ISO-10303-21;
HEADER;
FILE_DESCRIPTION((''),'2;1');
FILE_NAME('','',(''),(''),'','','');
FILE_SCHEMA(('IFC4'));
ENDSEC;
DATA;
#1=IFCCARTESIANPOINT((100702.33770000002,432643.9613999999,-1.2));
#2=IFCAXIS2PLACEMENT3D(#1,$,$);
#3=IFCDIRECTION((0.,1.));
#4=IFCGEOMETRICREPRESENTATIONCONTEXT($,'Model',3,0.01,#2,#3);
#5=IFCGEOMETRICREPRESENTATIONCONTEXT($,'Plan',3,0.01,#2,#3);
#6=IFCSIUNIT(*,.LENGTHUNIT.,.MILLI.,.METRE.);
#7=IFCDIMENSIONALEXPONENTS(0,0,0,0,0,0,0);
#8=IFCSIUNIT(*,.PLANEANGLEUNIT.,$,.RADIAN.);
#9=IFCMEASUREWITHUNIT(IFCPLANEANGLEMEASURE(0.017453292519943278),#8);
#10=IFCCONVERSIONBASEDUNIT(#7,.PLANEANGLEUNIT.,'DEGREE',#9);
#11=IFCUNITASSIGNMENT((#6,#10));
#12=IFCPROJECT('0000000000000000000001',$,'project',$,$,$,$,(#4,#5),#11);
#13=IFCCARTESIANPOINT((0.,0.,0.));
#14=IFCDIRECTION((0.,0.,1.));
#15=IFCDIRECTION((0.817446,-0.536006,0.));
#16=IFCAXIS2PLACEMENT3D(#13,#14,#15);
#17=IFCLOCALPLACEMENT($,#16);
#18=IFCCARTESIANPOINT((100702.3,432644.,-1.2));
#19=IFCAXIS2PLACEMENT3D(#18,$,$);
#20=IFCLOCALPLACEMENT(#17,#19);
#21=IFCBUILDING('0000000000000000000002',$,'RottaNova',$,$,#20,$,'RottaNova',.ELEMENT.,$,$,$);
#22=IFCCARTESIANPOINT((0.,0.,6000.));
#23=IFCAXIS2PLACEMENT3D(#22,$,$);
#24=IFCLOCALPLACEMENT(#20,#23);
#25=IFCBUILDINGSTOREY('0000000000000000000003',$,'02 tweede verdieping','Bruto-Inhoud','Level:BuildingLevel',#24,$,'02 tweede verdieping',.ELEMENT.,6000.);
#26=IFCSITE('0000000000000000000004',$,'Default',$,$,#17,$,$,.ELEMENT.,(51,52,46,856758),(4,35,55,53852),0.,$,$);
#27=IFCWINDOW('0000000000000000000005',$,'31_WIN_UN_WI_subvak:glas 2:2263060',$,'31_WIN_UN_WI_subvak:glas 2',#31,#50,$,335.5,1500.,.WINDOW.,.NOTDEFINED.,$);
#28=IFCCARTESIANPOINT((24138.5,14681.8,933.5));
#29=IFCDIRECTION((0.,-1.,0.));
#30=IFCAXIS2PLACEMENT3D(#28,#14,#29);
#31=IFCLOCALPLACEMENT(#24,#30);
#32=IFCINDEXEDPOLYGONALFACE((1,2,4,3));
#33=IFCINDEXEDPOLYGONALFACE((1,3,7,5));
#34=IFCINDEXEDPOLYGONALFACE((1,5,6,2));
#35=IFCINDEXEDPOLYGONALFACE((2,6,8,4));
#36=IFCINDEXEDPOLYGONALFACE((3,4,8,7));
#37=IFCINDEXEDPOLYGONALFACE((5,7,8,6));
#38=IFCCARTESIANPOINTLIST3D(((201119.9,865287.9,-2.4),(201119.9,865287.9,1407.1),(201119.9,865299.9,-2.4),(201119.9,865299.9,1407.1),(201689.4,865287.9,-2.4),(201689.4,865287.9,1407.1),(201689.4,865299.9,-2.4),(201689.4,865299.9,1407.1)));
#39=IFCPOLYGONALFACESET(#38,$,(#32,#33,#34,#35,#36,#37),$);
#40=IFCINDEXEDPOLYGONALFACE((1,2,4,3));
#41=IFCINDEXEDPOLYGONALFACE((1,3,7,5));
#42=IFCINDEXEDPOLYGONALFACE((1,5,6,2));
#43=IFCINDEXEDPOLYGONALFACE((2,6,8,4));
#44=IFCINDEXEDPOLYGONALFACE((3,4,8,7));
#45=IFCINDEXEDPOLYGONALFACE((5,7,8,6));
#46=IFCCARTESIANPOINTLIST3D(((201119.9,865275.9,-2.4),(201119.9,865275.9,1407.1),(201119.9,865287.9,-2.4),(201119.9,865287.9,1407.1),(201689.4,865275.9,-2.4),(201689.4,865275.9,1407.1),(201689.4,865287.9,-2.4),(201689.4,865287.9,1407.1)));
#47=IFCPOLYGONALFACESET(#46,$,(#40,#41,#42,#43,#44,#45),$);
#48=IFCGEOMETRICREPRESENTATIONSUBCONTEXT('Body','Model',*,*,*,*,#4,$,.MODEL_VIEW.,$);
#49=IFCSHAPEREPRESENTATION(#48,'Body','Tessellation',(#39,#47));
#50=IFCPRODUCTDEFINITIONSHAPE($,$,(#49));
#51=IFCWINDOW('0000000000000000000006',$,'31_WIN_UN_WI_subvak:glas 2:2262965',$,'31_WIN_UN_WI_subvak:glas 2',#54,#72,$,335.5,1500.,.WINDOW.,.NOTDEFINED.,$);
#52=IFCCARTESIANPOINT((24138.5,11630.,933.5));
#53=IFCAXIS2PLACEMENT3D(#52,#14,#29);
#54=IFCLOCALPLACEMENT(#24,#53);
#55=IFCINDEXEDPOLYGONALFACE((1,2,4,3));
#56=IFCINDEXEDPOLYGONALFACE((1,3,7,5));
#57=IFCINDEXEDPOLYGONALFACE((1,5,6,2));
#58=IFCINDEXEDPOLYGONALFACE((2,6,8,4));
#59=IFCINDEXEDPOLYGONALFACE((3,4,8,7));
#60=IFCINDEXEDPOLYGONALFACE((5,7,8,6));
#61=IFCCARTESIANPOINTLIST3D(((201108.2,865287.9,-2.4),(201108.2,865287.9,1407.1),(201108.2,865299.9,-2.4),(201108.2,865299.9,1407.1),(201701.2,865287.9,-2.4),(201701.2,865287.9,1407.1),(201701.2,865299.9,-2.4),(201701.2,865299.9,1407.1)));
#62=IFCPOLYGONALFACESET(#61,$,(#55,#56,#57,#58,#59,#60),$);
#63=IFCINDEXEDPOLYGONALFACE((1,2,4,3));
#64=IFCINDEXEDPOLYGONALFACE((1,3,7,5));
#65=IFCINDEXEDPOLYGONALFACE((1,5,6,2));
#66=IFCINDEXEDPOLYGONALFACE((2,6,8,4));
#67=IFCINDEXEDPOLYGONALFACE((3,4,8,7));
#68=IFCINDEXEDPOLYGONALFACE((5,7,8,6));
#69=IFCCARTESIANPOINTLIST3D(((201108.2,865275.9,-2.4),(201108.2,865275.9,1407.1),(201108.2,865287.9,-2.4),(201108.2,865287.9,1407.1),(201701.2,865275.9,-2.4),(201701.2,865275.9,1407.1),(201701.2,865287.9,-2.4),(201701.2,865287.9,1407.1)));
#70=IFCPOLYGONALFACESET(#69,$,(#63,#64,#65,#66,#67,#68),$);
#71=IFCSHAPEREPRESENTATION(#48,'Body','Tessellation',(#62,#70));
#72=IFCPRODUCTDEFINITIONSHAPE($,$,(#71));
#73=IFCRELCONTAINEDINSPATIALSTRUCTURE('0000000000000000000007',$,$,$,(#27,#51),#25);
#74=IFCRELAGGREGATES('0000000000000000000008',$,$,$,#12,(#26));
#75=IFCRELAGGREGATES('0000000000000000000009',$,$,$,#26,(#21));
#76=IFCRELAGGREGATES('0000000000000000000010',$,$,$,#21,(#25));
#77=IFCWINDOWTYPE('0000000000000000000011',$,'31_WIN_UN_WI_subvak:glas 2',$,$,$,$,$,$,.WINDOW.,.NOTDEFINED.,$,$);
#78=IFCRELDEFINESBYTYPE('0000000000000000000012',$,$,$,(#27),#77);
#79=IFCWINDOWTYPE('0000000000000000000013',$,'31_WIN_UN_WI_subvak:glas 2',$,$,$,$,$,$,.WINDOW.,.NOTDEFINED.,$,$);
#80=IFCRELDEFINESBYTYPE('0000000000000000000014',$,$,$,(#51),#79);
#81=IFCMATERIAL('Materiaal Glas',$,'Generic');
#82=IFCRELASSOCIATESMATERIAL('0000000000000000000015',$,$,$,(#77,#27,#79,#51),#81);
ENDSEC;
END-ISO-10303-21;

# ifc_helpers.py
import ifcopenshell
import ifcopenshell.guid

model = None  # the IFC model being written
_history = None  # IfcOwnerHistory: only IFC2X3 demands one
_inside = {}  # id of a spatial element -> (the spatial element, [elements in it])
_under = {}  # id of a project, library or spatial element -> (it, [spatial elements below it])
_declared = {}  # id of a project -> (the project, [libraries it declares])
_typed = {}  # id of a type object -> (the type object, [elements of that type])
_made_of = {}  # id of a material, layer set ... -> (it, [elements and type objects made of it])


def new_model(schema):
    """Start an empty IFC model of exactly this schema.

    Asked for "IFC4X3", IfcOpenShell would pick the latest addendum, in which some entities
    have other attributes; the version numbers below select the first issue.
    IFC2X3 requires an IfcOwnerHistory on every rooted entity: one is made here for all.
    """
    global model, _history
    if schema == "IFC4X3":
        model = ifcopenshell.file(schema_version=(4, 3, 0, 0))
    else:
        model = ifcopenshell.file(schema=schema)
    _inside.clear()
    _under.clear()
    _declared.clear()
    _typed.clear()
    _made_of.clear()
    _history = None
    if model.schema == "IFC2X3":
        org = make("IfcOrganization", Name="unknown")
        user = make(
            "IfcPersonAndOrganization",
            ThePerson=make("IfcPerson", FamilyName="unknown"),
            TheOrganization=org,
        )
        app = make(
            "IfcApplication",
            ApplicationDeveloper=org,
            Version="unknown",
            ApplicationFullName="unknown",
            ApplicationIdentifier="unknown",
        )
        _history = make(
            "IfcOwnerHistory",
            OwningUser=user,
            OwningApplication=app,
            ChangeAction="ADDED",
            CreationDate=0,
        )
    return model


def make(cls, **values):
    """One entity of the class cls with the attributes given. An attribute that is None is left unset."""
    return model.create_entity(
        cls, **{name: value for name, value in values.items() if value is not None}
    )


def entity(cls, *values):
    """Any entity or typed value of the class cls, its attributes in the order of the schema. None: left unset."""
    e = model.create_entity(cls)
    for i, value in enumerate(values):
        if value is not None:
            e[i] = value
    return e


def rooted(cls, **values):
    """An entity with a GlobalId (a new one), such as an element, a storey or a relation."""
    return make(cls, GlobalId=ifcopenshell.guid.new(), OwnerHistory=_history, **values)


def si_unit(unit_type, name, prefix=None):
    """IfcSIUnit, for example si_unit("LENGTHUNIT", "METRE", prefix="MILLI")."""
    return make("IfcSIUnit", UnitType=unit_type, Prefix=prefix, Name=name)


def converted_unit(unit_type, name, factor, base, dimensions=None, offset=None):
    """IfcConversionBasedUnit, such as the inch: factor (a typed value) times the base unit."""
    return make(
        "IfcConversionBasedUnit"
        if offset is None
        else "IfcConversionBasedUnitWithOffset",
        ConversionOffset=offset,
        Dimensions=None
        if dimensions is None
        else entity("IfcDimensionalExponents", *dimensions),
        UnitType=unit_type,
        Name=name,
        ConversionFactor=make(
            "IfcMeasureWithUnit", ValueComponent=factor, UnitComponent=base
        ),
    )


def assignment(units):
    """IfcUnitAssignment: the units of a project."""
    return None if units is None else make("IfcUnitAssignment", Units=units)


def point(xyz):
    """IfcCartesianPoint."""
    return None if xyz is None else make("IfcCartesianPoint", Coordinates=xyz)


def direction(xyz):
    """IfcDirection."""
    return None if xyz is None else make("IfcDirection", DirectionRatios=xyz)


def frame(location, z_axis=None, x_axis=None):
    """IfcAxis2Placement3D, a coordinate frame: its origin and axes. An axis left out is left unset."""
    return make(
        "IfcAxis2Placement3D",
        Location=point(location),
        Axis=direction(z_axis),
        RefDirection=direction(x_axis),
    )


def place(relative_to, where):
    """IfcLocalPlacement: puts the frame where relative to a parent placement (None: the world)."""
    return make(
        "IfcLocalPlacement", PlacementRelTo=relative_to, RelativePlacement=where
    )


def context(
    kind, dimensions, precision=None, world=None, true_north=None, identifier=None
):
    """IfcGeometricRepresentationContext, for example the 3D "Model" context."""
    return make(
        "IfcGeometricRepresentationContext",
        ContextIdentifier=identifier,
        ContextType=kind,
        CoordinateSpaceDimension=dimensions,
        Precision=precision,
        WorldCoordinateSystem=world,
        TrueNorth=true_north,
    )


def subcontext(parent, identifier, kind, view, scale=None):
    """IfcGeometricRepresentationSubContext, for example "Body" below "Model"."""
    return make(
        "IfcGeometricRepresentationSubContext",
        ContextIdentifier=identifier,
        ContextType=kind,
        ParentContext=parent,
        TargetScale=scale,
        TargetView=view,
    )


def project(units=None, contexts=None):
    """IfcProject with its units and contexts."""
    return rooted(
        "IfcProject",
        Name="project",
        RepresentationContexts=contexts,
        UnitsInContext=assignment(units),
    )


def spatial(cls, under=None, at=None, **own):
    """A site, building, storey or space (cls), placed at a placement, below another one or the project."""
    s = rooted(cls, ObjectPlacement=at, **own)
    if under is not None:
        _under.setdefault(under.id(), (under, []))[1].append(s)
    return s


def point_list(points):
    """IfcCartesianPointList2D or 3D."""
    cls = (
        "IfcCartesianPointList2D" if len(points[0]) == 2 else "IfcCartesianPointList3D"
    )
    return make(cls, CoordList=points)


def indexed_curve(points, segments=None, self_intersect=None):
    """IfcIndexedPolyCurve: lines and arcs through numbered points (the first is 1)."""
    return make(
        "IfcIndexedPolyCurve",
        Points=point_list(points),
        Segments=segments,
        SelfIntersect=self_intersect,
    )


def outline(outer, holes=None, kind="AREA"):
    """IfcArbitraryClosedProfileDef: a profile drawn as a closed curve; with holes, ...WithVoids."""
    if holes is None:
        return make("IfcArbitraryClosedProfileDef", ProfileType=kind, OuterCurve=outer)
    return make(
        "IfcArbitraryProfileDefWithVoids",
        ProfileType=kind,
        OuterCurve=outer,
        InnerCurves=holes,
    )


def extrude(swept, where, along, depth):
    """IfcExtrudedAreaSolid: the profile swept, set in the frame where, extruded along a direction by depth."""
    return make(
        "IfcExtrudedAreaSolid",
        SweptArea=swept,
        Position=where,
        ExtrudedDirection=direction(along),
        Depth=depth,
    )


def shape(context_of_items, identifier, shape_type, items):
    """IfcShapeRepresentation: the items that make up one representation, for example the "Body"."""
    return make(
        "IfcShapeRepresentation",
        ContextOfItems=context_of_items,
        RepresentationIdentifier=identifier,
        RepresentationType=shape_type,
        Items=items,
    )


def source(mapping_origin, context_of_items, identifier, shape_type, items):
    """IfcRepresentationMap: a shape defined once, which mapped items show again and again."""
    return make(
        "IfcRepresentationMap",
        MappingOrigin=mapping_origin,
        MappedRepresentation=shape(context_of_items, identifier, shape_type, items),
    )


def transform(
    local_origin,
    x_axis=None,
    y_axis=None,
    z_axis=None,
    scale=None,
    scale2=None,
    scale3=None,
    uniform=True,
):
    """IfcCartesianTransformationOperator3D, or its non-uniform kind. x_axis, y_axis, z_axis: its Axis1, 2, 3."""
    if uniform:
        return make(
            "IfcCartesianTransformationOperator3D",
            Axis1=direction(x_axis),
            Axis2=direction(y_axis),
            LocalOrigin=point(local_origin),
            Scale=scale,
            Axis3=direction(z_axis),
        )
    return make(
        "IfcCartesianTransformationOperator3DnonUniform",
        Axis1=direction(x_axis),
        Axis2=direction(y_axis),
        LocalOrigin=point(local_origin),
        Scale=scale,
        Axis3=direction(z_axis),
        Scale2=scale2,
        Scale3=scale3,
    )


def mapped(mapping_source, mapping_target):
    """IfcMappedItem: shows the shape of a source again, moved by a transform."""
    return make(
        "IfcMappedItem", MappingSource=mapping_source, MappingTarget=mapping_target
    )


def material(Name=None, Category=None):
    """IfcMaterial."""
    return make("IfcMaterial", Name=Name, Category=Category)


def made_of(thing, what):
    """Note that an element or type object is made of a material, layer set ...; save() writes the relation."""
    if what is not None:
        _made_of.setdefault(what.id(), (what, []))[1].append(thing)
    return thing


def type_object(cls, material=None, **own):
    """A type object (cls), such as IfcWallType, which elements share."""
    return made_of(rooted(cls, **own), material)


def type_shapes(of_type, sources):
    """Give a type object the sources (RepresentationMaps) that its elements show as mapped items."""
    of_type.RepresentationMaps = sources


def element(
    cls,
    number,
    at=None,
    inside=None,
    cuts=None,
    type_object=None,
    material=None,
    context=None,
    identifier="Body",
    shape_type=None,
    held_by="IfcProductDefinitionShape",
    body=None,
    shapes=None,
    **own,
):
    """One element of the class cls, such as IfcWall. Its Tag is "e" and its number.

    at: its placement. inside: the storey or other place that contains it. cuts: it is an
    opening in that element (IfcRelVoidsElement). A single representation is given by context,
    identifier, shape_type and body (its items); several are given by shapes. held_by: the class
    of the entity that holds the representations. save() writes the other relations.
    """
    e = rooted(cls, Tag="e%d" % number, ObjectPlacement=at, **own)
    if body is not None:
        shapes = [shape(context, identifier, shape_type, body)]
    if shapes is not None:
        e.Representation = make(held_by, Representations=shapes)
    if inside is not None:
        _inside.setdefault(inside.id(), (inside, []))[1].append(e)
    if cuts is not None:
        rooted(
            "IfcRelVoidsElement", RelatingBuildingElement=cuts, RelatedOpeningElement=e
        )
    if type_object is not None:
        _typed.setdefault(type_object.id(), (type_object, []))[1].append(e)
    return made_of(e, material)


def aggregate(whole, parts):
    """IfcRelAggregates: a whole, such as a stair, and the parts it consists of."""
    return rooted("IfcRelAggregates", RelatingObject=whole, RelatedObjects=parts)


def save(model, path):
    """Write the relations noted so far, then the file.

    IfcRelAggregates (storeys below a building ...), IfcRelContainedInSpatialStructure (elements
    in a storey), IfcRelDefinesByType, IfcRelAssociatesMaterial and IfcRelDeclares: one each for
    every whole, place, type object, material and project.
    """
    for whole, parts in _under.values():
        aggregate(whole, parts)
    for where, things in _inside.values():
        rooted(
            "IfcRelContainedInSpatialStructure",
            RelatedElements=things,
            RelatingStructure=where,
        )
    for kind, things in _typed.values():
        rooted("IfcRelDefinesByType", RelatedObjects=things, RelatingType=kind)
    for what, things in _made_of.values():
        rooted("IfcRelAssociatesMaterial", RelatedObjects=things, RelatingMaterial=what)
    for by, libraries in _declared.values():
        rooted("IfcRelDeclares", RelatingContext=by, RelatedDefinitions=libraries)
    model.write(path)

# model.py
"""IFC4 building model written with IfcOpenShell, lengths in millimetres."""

from ifc_helpers import new_model, entity, si_unit, converted_unit, direction, frame, place, context, subcontext, project, spatial, indexed_curve, outline, extrude, source, transform, mapped, material, type_object, type_shapes, element, save


model = new_model("IFC4")

# Units and contexts
model_context = context("Model", 3, precision=0.01, world=frame((100702.33770000002, 432643.9613999999, -1.2)), true_north=direction((0.0, 1.0)))
plan_context = context("Plan", 3, precision=0.01, world=frame((100702.33770000002, 432643.9613999999, -1.2)), true_north=direction((0.0, 1.0)))
body_context = subcontext(model_context, "Body", "Model", "MODEL_VIEW")
ifc_project = project(units=[si_unit("LENGTHUNIT", "METRE", prefix="MILLI"), converted_unit("PLANEANGLEUNIT", "DEGREE", entity("IfcPlaneAngleMeasure", 0.017453292519943278), si_unit("PLANEANGLEUNIT", "RADIAN"), dimensions=[0, 0, 0, 0, 0, 0, 0])], contexts=[model_context, plan_context])

# Site, building, storey
site_placement = place(None, frame((0.0, 0.0, 0.0), z_axis=(0.0, 0.0, 1.0), x_axis=(0.817446, -0.536006, 0.0)))
site = spatial("IfcSite", under=ifc_project, at=site_placement, Name="Default", CompositionType="ELEMENT", RefLatitude=(51, 52, 46, 856758), RefLongitude=(4, 35, 55, 53852), RefElevation=0.0)
building_placement = place(site_placement, frame((100702.3, 432644.0, -1.2)))
building = spatial("IfcBuilding", under=site, at=building_placement, Name="RottaNova", LongName="RottaNova", CompositionType="ELEMENT")
storey_placement = place(building_placement, frame((0.0, 0.0, 6000.0)))
storey = spatial("IfcBuildingStorey", under=building, at=storey_placement, Name="02 tweede verdieping", Description="Bruto-Inhoud", ObjectType="Level:BuildingLevel", LongName="02 tweede verdieping", CompositionType="ELEMENT", Elevation=6000.0)

# Shared definitions
ifc_material_1 = material(Name="Materiaal Glas", Category="Generic")

# Windows
window_type_1 = type_object("IfcWindowType", Name="31_WIN_UN_WI_subvak:glas 2", PartitioningType="NOTDEFINED", PredefinedType="WINDOW", material=ifc_material_1)
shared_shape_1 = source(frame((100702.3, 432644.0, -1.2)), body_context, "Body", "SweptSolid", [
    extrude(outline(indexed_curve([(-6.0, -284.7), (6.0, -284.7), (6.0, 284.7), (-6.0, 284.7), (-6.0, -284.7)], self_intersect=False)), frame((0.0, 6.0, 0.0), z_axis=(0.0, 0.0, 1.0), x_axis=(0.0, -1.0, 0.0)), (0.0, 0.0, 1.0), 1409.5),
    extrude(outline(indexed_curve([(-6.0, -284.8), (6.0, -284.8), (6.0, 284.8), (-6.0, 284.8), (-6.0, -284.8)], self_intersect=False)), frame((0.0, -6.0, 0.0), z_axis=(0.0, 0.0, 1.0), x_axis=(0.0, -1.0, 0.0)), (0.0, 0.0, 1.0), 1409.5),
])
type_shapes(window_type_1, [shared_shape_1])
for number, where, z_axis, x_axis, name in (
    (1, (24138.5, 14681.8, 933.5), (0.0, 0.0, 1.0), (0.0, -1.0, 0.0), "31_WIN_UN_WI_subvak:glas 2:2263060"),
):
    element("IfcWindow", number, at=place(storey_placement, frame(where, z_axis=z_axis, x_axis=x_axis)), inside=storey, type_object=window_type_1, material=ifc_material_1, Name=name, ObjectType="31_WIN_UN_WI_subvak:glas 2", OverallHeight=335.5, OverallWidth=1500.0, PartitioningType="NOTDEFINED", PredefinedType="WINDOW", context=body_context, shape_type="MappedRepresentation", body=[
        mapped(shared_shape_1, transform((100702.3, 432644.0, -1.2), scale=1.0)),
    ])
window_type_2 = type_object("IfcWindowType", Name="31_WIN_UN_WI_subvak:glas 2", PartitioningType="NOTDEFINED", PredefinedType="WINDOW", material=ifc_material_1)
shared_shape_2 = source(frame((100702.3, 432644.0, -1.2)), body_context, "Body", "SweptSolid", [
    extrude(outline(indexed_curve([(-6.0, -296.5), (6.0, -296.5), (6.0, 296.5), (-6.0, 296.5), (-6.0, -296.5)], self_intersect=False)), frame((0.0, 6.0, 0.0), z_axis=(0.0, 0.0, 1.0), x_axis=(0.0, -1.0, 0.0)), (0.0, 0.0, 1.0), 1409.5),
    extrude(outline(indexed_curve([(-6.0, -296.5), (6.0, -296.5), (6.0, 296.5), (-6.0, 296.5), (-6.0, -296.5)], self_intersect=False)), frame((0.0, -6.0, 0.0), z_axis=(0.0, 0.0, 1.0), x_axis=(0.0, -1.0, 0.0)), (0.0, 0.0, 1.0), 1409.5),
])
type_shapes(window_type_2, [shared_shape_2])
window_1_placement = place(storey_placement, frame((24138.5, 11630.0, 933.5), z_axis=(0.0, 0.0, 1.0), x_axis=(0.0, -1.0, 0.0)))
element("IfcWindow", 2, at=window_1_placement, inside=storey, type_object=window_type_2, material=ifc_material_1, Name="31_WIN_UN_WI_subvak:glas 2:2262965", ObjectType="31_WIN_UN_WI_subvak:glas 2", OverallHeight=335.5, OverallWidth=1500.0, PartitioningType="NOTDEFINED", PredefinedType="WINDOW", context=body_context, shape_type="MappedRepresentation", body=[
    mapped(shared_shape_2, transform((100702.3, 432644.0, -1.2), scale=1.0)),
])

save(model, "model.ifc")
